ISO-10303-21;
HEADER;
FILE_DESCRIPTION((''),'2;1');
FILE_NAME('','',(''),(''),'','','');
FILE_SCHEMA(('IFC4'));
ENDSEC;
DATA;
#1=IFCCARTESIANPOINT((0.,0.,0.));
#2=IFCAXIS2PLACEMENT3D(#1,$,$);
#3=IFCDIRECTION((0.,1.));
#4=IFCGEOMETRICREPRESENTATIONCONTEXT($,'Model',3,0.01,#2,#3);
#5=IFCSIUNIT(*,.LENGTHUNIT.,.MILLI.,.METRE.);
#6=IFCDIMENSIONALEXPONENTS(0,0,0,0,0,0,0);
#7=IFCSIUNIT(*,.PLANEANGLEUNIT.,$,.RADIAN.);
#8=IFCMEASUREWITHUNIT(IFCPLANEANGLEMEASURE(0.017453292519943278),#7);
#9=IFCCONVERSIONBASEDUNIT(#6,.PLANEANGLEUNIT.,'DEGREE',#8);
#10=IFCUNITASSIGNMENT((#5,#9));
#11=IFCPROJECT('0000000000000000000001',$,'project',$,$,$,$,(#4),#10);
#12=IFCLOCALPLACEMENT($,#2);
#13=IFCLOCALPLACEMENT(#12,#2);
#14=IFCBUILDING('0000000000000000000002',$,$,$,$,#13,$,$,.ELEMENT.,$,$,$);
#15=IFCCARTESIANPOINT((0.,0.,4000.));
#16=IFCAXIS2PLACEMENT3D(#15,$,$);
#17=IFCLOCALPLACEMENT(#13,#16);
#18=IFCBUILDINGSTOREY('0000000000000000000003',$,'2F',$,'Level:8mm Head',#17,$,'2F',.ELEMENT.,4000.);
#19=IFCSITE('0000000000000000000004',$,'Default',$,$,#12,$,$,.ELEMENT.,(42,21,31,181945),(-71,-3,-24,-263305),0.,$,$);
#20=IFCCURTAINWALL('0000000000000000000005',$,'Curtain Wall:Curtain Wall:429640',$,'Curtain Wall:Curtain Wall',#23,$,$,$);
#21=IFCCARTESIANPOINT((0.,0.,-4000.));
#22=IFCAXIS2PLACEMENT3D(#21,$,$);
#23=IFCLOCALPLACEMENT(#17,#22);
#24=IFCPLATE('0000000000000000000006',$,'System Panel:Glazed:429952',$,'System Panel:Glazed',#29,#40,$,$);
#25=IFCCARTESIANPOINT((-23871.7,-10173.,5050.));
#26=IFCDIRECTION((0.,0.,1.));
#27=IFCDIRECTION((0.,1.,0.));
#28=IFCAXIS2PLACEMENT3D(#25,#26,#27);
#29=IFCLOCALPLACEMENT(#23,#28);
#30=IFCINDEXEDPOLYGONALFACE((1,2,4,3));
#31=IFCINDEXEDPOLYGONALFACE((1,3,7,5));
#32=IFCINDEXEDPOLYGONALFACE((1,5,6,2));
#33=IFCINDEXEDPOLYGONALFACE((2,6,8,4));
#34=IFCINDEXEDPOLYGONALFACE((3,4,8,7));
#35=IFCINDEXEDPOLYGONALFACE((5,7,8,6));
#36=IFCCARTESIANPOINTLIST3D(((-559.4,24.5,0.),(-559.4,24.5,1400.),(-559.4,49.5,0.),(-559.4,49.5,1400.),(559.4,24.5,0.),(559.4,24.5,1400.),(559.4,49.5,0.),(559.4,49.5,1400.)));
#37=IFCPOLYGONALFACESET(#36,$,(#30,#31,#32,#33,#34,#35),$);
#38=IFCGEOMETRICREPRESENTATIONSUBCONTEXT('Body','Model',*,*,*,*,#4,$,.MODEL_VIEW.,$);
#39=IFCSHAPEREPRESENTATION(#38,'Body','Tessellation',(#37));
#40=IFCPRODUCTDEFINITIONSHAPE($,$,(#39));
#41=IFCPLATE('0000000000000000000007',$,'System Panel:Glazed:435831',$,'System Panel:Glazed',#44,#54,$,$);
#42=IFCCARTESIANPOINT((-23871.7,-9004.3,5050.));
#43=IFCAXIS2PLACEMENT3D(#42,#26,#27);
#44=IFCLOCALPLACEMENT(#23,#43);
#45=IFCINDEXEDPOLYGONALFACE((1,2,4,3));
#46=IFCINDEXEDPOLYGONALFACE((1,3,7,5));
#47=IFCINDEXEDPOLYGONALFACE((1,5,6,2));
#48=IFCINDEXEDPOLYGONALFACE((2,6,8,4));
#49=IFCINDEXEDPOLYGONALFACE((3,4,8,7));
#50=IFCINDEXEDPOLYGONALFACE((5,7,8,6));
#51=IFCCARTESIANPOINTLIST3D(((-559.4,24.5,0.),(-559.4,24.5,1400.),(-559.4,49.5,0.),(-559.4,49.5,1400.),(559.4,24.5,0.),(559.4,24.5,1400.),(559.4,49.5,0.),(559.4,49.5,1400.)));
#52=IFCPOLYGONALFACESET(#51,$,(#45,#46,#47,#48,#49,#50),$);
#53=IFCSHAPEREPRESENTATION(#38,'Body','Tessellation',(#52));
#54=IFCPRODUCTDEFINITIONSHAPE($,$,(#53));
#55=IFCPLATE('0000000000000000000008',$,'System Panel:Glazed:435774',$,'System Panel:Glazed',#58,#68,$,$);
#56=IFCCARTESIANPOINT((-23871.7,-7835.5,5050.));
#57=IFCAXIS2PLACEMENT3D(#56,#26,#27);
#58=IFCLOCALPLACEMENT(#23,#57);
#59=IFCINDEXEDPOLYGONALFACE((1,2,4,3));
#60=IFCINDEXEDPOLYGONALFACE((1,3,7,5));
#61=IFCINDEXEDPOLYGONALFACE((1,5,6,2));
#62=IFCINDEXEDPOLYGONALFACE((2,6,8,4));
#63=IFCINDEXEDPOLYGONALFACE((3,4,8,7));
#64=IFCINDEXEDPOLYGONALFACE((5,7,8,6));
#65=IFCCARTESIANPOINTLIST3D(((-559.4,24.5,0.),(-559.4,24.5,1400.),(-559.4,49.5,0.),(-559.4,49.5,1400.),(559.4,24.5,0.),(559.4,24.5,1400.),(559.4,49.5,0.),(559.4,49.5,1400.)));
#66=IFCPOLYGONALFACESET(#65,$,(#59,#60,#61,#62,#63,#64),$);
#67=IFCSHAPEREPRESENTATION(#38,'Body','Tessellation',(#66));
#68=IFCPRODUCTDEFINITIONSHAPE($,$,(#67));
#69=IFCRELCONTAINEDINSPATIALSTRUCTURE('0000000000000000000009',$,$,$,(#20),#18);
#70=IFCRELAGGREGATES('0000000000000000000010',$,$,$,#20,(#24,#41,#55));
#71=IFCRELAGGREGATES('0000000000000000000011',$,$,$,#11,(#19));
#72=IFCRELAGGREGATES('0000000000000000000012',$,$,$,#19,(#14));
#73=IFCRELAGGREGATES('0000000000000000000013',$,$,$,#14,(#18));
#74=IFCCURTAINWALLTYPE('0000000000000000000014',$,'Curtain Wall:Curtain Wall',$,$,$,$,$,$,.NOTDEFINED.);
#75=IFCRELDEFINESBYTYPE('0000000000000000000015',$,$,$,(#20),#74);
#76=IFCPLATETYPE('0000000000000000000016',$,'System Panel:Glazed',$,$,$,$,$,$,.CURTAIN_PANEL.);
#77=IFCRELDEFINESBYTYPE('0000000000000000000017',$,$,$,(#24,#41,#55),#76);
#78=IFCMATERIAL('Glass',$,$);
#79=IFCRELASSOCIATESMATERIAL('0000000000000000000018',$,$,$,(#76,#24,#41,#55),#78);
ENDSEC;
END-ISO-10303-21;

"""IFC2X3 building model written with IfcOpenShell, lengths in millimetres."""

from ifc_helpers import new_model, entity, si_unit, converted_unit, direction, frame, origin, origin_2d_with_axis, place, context, subcontext, project, spatial, rectangle, extrude, source, transform, mapped, material, type_object, type_shapes, element, aggregate, save


model = new_model("IFC2X3")

# Units and contexts
model_context = context("Model", 3, precision=0.01, world=origin(), true_north=direction((0.0, 1.0)))
body_context = subcontext(model_context, "Body", "Model", "MODEL_VIEW")
ifc_project = project(units=[si_unit("LENGTHUNIT", "METRE", prefix="MILLI"), converted_unit("PLANEANGLEUNIT", "DEGREE", entity("IfcPlaneAngleMeasure", 0.017453292519943278), si_unit("PLANEANGLEUNIT", "RADIAN"), dimensions=[0, 0, 0, 0, 0, 0, 0])], contexts=[model_context])

# Site, building, storey
site_placement = place(None, origin())
site = spatial("IfcSite", under=ifc_project, at=site_placement, Name="Default", CompositionType="ELEMENT", RefLatitude=(42, 21, 31, 181945), RefLongitude=(-71, -3, -24, -263305), RefElevation=0.0)
building_placement = place(site_placement, origin())
building = spatial("IfcBuilding", under=site, at=building_placement, CompositionType="ELEMENT")
storey_placement = place(building_placement, frame((0.0, 0.0, 4000.0)))
storey = spatial("IfcBuildingStorey", under=building, at=storey_placement, Name="2F", ObjectType="Level:8mm Head", LongName="2F", CompositionType="ELEMENT", Elevation=4000.0)

# Curtain wall
curtain_wall_type = type_object("IfcCurtainWallType", Name="Curtain Wall:Curtain Wall", PredefinedType="NOTDEFINED")
curtain_wall_placement = place(storey_placement, frame((0.0, 0.0, -4000.0)))
curtain_wall = element("IfcCurtainWall", 1, at=curtain_wall_placement, inside=storey, type_object=curtain_wall_type, Name="Curtain Wall:Curtain Wall:429640", ObjectType="Curtain Wall:Curtain Wall")

# Plates
ifc_material_1 = material(Name="Glass")
plate_type = type_object("IfcPlateType", Name="System Panel:Glazed", PredefinedType="CURTAIN_PANEL", material=ifc_material_1)
shared_shape_1 = source(origin(), body_context, "Body", "SweptSolid", [
    extrude(rectangle(XDim=25.0, YDim=1118.8, at=origin_2d_with_axis()), frame((0.0, 37.0, 0.0), z_axis=(0.0, 0.0, 1.0), x_axis=(0.0, 1.0, 0.0)), (0.0, 0.0, 1.0), 1400.0),
])
type_shapes(plate_type, [shared_shape_1])
plate_1_placement = place(curtain_wall_placement, frame((-23871.7, -10173.0, 5050.0), z_axis=(0.0, 0.0, 1.0), x_axis=(0.0, 1.0, 0.0)))
plate_1 = element("IfcPlate", 2, at=plate_1_placement, type_object=plate_type, material=ifc_material_1, Name="System Panel:Glazed:429952", ObjectType="System Panel:Glazed", context=body_context, shape_type="MappedRepresentation", body=[
    mapped(shared_shape_1, transform((0.0, 0.0, 0.0), scale=1.0)),
])
plate_2_placement = place(curtain_wall_placement, frame((-23871.7, -9004.3, 5050.0), z_axis=(0.0, 0.0, 1.0), x_axis=(0.0, 1.0, 0.0)))
plate_2 = element("IfcPlate", 3, at=plate_2_placement, type_object=plate_type, material=ifc_material_1, Name="System Panel:Glazed:435831", ObjectType="System Panel:Glazed", context=body_context, shape_type="MappedRepresentation", body=[
    mapped(shared_shape_1, transform((0.0, 0.0, 0.0), scale=1.0)),
])
plate_3_placement = place(curtain_wall_placement, frame((-23871.7, -7835.5, 5050.0), z_axis=(0.0, 0.0, 1.0), x_axis=(0.0, 1.0, 0.0)))
plate_3 = element("IfcPlate", 4, at=plate_3_placement, type_object=plate_type, material=ifc_material_1, Name="System Panel:Glazed:435774", ObjectType="System Panel:Glazed", context=body_context, shape_type="MappedRepresentation", body=[
    mapped(shared_shape_1, transform((0.0, 0.0, 0.0), scale=1.0)),
])
aggregate(curtain_wall, [plate_1, plate_2, plate_3])

save(model, "model.ifc")
